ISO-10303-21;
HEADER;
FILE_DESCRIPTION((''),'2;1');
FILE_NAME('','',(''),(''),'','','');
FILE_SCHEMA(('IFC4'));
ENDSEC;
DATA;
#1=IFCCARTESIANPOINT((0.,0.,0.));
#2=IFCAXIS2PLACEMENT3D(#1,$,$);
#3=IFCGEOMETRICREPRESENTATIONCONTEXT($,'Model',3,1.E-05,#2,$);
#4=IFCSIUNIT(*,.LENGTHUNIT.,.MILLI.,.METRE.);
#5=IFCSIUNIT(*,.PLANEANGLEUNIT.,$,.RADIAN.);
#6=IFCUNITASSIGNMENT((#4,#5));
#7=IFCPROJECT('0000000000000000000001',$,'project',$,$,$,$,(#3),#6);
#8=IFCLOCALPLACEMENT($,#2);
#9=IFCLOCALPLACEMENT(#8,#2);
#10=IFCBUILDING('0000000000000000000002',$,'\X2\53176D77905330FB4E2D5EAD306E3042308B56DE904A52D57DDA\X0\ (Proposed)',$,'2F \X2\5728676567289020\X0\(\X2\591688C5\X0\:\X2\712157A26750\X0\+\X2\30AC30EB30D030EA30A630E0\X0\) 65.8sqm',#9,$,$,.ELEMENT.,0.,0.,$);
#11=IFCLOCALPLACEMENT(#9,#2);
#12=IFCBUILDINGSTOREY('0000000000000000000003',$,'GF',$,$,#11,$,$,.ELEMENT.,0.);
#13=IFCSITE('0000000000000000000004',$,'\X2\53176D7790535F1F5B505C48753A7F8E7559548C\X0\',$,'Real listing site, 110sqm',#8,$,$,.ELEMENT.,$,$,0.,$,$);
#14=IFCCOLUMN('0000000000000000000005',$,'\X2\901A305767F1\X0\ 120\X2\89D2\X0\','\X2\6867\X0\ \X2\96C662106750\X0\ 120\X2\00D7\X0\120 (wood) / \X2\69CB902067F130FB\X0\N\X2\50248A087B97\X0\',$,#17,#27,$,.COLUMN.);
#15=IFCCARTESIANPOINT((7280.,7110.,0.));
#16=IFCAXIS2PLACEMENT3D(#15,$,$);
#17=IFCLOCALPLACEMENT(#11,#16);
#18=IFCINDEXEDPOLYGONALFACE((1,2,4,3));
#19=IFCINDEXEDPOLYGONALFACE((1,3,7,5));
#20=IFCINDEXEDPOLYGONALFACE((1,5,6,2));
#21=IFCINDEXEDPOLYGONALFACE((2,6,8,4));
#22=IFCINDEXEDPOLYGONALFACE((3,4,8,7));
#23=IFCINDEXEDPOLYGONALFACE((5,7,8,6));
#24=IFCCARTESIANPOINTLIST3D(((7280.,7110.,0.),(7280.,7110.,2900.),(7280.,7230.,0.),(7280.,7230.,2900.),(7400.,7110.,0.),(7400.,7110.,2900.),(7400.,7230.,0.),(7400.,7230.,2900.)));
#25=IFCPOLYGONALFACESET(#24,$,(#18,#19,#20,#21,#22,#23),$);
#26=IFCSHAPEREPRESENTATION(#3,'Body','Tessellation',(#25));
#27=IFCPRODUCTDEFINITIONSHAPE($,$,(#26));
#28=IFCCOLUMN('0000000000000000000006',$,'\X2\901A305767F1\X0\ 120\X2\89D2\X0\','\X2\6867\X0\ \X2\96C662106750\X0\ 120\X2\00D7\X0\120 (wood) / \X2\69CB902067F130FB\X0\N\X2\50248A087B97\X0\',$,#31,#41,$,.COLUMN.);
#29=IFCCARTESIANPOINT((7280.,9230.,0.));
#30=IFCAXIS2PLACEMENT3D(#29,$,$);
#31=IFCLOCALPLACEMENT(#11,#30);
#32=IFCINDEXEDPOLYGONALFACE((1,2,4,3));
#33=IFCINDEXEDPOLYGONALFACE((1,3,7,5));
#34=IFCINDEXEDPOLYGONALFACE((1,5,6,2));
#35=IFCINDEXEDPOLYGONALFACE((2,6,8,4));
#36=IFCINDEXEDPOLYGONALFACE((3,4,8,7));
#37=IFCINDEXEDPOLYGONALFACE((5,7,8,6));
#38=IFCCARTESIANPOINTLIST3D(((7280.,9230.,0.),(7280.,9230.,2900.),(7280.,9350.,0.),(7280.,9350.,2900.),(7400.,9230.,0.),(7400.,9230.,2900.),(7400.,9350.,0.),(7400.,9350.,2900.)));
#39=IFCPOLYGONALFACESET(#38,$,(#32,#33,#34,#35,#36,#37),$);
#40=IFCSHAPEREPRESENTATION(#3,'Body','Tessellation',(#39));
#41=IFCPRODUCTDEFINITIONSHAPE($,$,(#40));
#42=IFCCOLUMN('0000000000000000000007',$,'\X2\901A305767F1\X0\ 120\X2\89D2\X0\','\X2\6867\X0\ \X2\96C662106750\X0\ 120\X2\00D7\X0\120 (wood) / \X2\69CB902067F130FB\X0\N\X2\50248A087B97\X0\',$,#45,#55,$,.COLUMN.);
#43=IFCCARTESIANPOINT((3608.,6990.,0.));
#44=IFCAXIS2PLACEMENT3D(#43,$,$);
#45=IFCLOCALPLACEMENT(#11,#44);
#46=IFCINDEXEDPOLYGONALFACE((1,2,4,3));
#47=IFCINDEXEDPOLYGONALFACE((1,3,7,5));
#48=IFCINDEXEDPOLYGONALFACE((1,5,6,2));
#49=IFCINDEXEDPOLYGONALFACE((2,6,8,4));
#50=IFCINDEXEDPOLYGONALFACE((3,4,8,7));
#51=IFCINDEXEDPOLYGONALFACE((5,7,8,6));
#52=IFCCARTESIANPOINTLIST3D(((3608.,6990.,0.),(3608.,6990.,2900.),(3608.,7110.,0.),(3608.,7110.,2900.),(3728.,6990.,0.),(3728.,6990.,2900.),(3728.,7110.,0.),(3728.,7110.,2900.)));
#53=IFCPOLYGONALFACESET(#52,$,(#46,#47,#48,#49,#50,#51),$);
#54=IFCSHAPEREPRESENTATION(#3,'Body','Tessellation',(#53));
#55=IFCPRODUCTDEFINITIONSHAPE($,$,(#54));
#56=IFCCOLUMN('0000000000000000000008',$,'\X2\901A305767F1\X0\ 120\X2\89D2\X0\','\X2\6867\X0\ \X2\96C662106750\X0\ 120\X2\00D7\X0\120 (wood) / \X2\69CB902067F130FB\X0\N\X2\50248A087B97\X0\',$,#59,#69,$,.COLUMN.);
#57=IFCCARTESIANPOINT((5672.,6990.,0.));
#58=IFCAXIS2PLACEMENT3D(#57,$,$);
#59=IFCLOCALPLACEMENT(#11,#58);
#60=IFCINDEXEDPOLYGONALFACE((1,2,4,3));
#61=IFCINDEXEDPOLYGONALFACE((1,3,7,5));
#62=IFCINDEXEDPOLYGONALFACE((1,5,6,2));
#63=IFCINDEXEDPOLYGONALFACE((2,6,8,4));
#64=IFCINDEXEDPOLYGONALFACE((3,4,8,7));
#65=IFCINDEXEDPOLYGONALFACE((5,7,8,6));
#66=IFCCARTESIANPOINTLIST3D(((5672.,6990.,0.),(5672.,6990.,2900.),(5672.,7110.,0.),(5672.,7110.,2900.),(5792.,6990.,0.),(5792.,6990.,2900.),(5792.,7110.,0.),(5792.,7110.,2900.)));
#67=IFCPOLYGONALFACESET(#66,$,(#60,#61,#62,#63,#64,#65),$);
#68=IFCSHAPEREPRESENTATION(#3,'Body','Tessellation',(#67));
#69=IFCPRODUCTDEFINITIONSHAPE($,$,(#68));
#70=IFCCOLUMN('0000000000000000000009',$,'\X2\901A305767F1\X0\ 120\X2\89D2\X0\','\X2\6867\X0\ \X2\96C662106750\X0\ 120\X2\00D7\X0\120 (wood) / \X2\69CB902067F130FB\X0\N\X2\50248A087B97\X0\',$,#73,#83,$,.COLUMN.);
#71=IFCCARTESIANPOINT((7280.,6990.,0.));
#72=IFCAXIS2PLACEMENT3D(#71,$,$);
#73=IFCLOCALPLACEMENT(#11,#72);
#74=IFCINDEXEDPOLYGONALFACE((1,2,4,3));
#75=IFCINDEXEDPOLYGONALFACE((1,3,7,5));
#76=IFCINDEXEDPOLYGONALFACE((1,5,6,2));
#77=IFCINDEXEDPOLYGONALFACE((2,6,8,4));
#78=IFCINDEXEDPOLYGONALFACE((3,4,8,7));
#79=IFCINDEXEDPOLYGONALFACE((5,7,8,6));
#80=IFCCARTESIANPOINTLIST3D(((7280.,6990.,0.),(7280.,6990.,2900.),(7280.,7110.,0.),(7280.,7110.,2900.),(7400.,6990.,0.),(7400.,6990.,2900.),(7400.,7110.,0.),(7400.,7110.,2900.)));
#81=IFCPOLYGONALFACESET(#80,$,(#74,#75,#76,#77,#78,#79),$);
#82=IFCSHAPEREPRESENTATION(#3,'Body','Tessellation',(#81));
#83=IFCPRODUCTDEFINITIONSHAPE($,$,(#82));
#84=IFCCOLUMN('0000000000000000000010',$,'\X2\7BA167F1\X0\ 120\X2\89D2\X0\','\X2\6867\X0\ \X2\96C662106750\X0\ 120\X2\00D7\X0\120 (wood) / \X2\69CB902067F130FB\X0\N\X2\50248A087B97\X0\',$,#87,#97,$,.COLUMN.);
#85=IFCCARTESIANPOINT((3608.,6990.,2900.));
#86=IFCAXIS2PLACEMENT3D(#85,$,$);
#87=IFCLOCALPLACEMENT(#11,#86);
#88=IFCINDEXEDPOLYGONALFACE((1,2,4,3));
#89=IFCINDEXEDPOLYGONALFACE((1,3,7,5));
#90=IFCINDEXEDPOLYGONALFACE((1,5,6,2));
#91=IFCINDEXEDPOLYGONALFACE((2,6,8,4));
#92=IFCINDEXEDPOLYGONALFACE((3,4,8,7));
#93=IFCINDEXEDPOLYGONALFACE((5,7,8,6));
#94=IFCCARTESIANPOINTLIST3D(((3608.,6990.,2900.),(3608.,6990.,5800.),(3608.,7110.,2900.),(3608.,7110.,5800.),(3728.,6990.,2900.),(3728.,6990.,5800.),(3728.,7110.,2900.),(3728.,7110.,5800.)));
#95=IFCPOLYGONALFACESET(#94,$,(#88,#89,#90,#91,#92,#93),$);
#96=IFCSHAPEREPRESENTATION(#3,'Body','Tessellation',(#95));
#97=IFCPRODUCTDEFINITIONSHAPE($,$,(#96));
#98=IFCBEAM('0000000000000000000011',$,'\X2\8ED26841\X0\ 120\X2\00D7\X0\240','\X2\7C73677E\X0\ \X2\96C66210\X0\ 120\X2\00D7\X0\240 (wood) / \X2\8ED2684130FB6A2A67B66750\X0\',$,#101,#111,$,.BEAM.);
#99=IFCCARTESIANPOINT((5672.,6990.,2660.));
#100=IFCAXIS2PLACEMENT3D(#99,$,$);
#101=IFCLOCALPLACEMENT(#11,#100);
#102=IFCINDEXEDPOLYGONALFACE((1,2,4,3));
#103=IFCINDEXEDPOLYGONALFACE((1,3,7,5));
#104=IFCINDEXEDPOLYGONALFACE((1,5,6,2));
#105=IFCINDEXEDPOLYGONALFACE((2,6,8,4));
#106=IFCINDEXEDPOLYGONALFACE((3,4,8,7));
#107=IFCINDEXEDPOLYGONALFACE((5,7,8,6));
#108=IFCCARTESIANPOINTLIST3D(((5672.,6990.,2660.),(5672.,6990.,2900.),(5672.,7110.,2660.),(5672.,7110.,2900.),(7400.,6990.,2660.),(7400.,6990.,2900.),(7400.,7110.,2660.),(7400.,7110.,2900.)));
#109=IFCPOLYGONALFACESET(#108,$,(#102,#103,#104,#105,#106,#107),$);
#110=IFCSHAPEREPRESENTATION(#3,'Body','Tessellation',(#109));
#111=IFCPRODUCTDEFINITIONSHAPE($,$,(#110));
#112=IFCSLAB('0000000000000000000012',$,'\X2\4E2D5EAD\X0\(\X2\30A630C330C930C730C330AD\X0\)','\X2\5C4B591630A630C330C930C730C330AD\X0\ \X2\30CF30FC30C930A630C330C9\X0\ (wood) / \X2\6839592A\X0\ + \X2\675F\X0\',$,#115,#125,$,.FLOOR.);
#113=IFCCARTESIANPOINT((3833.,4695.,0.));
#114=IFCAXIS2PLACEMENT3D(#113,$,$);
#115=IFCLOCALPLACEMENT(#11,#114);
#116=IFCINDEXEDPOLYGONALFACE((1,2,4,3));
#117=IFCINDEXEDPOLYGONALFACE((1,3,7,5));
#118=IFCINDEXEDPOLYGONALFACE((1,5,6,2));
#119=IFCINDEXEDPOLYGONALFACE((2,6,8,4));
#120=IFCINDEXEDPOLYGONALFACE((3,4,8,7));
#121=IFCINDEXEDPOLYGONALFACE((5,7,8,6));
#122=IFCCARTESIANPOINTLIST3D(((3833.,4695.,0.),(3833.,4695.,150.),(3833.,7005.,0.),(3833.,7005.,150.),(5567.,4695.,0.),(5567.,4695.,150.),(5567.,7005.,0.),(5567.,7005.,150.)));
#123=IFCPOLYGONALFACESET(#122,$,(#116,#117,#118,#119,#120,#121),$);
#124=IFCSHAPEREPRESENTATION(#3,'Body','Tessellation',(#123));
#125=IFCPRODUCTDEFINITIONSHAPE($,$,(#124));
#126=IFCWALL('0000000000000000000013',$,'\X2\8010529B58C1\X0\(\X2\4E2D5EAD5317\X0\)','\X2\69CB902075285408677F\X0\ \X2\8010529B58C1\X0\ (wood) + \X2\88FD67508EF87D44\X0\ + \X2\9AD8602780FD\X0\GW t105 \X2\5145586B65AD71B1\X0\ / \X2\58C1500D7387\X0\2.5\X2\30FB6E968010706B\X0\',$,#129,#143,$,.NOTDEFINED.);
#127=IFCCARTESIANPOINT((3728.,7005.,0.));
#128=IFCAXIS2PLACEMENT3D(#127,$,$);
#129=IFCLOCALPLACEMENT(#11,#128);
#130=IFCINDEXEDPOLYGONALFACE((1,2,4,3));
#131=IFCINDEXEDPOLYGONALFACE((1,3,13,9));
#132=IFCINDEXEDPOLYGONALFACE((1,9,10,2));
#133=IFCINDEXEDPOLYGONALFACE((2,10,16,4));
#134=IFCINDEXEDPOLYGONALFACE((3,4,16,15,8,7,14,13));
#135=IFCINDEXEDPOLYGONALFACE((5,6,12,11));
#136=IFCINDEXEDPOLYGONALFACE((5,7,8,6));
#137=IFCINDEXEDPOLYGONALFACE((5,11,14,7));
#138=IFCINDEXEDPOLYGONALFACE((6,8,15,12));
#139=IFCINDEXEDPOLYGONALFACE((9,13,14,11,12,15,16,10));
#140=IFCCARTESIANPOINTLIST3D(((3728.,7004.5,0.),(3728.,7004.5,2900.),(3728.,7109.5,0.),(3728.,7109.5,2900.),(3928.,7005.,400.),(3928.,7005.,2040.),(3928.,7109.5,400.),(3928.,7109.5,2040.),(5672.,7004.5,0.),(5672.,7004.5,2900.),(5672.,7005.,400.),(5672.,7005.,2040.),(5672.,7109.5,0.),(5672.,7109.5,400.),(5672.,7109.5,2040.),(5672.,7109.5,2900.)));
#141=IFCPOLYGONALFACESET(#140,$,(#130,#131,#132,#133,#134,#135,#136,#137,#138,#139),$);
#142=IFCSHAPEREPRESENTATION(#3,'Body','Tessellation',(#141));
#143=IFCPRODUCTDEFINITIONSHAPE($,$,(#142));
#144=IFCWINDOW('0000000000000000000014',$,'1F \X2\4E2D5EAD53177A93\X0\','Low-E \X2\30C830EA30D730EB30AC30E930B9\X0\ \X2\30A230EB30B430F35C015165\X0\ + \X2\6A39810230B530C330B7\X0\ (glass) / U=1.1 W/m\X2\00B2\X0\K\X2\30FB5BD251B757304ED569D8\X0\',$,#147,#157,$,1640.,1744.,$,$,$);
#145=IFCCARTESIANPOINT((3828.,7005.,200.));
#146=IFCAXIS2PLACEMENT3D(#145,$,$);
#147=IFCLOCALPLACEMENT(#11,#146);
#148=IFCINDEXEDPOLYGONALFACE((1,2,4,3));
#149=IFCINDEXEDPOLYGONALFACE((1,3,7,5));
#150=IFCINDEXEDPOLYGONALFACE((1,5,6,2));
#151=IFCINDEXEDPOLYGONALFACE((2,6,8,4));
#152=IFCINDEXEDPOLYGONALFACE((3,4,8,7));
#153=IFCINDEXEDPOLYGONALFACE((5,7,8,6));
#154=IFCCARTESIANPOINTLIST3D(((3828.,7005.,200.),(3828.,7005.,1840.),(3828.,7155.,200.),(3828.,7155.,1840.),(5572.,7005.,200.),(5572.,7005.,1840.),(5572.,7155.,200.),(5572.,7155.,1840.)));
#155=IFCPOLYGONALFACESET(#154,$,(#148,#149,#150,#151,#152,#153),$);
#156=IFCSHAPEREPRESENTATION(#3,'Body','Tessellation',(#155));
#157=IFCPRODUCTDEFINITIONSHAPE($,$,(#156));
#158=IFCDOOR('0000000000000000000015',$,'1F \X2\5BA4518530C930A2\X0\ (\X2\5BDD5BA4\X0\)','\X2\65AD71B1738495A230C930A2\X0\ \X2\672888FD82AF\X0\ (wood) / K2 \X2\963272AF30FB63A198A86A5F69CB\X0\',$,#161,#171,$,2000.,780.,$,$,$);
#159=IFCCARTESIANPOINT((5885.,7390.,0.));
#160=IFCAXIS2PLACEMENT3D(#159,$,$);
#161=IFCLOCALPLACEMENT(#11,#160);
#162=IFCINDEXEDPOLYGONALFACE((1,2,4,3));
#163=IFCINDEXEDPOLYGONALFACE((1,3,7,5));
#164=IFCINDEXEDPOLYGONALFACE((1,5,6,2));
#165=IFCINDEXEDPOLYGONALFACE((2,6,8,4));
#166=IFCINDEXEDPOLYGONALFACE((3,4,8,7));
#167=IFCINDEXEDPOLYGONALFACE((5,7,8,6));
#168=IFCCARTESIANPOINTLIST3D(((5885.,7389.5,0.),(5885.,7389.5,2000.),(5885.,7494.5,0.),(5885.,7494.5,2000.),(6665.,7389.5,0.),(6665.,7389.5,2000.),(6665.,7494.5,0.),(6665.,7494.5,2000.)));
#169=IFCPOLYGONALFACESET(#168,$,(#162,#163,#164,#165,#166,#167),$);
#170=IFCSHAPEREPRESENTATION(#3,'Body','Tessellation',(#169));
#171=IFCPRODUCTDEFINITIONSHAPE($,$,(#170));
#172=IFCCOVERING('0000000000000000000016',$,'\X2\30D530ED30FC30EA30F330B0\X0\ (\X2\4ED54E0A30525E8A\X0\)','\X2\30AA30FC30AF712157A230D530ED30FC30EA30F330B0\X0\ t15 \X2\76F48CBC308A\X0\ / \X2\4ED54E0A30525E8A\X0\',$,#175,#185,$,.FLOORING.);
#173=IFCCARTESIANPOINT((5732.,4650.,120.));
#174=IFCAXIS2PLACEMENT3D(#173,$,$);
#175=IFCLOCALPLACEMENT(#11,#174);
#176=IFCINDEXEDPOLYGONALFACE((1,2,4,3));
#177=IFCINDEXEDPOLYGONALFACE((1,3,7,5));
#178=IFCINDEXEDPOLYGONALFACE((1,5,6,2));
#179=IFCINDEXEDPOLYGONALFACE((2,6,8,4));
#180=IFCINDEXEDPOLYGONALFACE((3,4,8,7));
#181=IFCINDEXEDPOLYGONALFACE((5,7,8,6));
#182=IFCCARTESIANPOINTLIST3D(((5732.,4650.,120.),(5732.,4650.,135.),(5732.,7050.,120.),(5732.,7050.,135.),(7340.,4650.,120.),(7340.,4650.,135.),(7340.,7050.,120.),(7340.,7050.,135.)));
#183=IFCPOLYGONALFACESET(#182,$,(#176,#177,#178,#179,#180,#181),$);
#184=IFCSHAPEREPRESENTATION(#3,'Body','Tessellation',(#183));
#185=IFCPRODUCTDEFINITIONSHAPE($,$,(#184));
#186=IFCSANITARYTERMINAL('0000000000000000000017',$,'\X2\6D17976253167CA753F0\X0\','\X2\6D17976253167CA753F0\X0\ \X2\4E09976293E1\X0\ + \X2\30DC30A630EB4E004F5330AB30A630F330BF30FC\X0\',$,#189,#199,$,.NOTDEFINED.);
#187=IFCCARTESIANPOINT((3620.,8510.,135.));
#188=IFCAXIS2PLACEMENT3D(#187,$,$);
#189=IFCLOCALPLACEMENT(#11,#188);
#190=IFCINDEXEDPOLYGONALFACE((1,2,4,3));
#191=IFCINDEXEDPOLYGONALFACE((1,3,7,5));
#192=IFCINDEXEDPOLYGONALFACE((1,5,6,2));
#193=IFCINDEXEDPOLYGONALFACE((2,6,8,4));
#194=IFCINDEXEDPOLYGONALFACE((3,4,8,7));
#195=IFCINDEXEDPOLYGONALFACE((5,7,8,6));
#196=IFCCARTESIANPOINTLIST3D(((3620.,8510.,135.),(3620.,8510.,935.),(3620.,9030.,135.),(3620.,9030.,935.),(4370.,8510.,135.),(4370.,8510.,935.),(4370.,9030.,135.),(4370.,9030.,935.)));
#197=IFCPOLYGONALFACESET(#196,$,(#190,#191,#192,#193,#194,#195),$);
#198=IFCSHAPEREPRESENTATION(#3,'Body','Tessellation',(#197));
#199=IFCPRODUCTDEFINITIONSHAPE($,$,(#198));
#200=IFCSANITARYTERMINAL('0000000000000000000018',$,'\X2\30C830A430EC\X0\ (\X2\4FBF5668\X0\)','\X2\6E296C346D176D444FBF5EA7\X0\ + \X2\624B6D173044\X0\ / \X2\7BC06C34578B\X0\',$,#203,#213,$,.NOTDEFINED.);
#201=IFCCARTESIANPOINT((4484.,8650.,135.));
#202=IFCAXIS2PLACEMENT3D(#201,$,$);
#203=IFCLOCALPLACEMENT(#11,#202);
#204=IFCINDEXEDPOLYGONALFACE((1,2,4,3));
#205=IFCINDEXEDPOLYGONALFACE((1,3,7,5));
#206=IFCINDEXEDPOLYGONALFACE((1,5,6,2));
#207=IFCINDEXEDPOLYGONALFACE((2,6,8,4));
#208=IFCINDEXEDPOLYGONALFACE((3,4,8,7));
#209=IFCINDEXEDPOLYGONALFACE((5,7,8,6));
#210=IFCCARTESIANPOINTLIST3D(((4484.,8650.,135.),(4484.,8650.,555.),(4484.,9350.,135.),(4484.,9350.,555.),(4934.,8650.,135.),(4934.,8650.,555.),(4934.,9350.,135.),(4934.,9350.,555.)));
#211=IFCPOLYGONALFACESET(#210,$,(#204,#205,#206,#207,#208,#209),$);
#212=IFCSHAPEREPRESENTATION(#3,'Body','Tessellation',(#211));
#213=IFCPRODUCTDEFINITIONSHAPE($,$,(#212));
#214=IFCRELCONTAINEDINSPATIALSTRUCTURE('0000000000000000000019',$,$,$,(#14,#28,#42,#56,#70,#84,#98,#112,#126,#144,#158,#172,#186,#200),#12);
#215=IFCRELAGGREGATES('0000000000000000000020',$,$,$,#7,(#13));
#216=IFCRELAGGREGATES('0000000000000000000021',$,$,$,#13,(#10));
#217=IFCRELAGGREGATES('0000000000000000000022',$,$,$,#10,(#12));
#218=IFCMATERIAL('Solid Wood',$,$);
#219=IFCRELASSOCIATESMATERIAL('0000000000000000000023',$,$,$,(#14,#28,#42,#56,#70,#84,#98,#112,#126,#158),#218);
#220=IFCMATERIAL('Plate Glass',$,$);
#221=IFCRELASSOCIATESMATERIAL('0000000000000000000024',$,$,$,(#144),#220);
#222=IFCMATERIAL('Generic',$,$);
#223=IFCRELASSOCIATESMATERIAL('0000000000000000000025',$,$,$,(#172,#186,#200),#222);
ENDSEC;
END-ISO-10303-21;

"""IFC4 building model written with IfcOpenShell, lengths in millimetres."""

from ifc_helpers import new_model, si_unit, frame, frame_2d, origin, place, context, project, spatial, rectangle, extrude, material, element, fill, save


model = new_model("IFC4")

# Units and contexts
model_context = context("Model", 3, precision=1e-05, world=origin())
ifc_project = project(units=[si_unit("LENGTHUNIT", "METRE", prefix="MILLI"), si_unit("PLANEANGLEUNIT", "RADIAN")], contexts=[model_context])

# Site, building, storey
site_placement = place(None, origin())
site = spatial("IfcSite", under=ifc_project, at=site_placement, Name="北海道弟子屈町美留和", ObjectType="Real listing site, 110sqm", CompositionType="ELEMENT", RefElevation=0.0)
building_placement = place(site_placement, origin())
building = spatial("IfcBuilding", under=site, at=building_placement, Name="北海道・中庭のある回遊動線 (Proposed)", ObjectType="2F 在来木造(外装:無垢材+ガルバリウム) 65.8sqm", CompositionType="ELEMENT", ElevationOfRefHeight=0.0, ElevationOfTerrain=0.0)
storey_placement = place(building_placement, origin())
storey = spatial("IfcBuildingStorey", under=building, at=storey_placement, Name="GF", CompositionType="ELEMENT", Elevation=0.0)

# Columns
ifc_material_1 = material(Name="Solid Wood")
column_1_placement = place(storey_placement, frame((7280.0, 7110.0, 0.0)))
element("IfcColumn", 1, at=column_1_placement, inside=storey, material=ifc_material_1, Name="通し柱 120角", Description="桧 集成材 120×120 (wood) / 構造柱・N値計算", PredefinedType="COLUMN", context=model_context, shape_type="SweptSolid", body=[
    extrude(rectangle(XDim=120.0, YDim=120.0, at=frame_2d((60.0, 60.0))), frame((7280.0, 7110.0, 0.0)), (0.0, 0.0, 1.0), 2900.0),
])
column_2_placement = place(storey_placement, frame((7280.0, 9230.0, 0.0)))
element("IfcColumn", 2, at=column_2_placement, inside=storey, material=ifc_material_1, Name="通し柱 120角", Description="桧 集成材 120×120 (wood) / 構造柱・N値計算", PredefinedType="COLUMN", context=model_context, shape_type="SweptSolid", body=[
    extrude(rectangle(XDim=120.0, YDim=120.0, at=frame_2d((60.0, 60.0))), frame((7280.0, 9230.0, 0.0)), (0.0, 0.0, 1.0), 2900.0),
])
column_3_placement = place(storey_placement, frame((3608.0, 6990.0, 0.0)))
element("IfcColumn", 3, at=column_3_placement, inside=storey, material=ifc_material_1, Name="通し柱 120角", Description="桧 集成材 120×120 (wood) / 構造柱・N値計算", PredefinedType="COLUMN", context=model_context, shape_type="SweptSolid", body=[
    extrude(rectangle(XDim=120.0, YDim=120.0, at=frame_2d((60.0, 60.0))), frame((3608.0, 6990.0, 0.0)), (0.0, 0.0, 1.0), 2900.0),
])
column_4_placement = place(storey_placement, frame((5672.0, 6990.0, 0.0)))
element("IfcColumn", 4, at=column_4_placement, inside=storey, material=ifc_material_1, Name="通し柱 120角", Description="桧 集成材 120×120 (wood) / 構造柱・N値計算", PredefinedType="COLUMN", context=model_context, shape_type="SweptSolid", body=[
    extrude(rectangle(XDim=120.0, YDim=120.0, at=frame_2d((60.0, 60.0))), frame((5672.0, 6990.0, 0.0)), (0.0, 0.0, 1.0), 2900.0),
])
column_5_placement = place(storey_placement, frame((7280.0, 6990.0, 0.0)))
element("IfcColumn", 5, at=column_5_placement, inside=storey, material=ifc_material_1, Name="通し柱 120角", Description="桧 集成材 120×120 (wood) / 構造柱・N値計算", PredefinedType="COLUMN", context=model_context, shape_type="SweptSolid", body=[
    extrude(rectangle(XDim=120.0, YDim=120.0, at=frame_2d((60.0, 60.0))), frame((7280.0, 6990.0, 0.0)), (0.0, 0.0, 1.0), 2900.0),
])
column_6_placement = place(storey_placement, frame((3608.0, 6990.0, 2900.0)))
element("IfcColumn", 6, at=column_6_placement, inside=storey, material=ifc_material_1, Name="管柱 120角", Description="桧 集成材 120×120 (wood) / 構造柱・N値計算", PredefinedType="COLUMN", context=model_context, shape_type="SweptSolid", body=[
    extrude(rectangle(XDim=120.0, YDim=120.0, at=frame_2d((60.0, 60.0))), frame((3608.0, 6990.0, 2900.0)), (0.0, 0.0, 1.0), 2900.0),
])

# Beam
beam_1_placement = place(storey_placement, frame((5672.0, 6990.0, 2660.0)))
element("IfcBeam", 7, at=beam_1_placement, inside=storey, material=ifc_material_1, Name="軒桁 120×240", Description="米松 集成 120×240 (wood) / 軒桁・横架材", PredefinedType="BEAM", context=model_context, shape_type="SweptSolid", body=[
    extrude(rectangle(XDim=1728.0, YDim=120.0, at=frame_2d((864.0, 60.0))), frame((5672.0, 6990.0, 2660.0)), (0.0, 0.0, 1.0), 240.0),
])

# Slab
slab_placement = place(storey_placement, frame((3833.0, 4695.0, 0.0)))
element("IfcSlab", 8, at=slab_placement, inside=storey, material=ifc_material_1, Name="中庭(ウッドデッキ)", Description="屋外ウッドデッキ ハードウッド (wood) / 根太 + 束", PredefinedType="FLOOR", context=model_context, shape_type="SweptSolid", body=[
    extrude(rectangle(XDim=1734.0, YDim=2310.0, at=frame_2d((867.0, 1155.0))), frame((3833.0, 4695.0, 0.0)), (0.0, 0.0, 1.0), 150.0),
])

# Wall, opening, window
wall_1_placement = place(storey_placement, frame((3728.0, 7005.0, 0.0)))
wall_1 = element("IfcWall", 9, at=wall_1_placement, inside=storey, material=ifc_material_1, Name="耐力壁(中庭北)", Description="構造用合板 耐力壁 (wood) + 製材軸組 + 高性能GW t105 充填断熱 / 壁倍率2.5・準耐火", PredefinedType="NOTDEFINED", context=model_context, shape_type="SweptSolid", body=[
    extrude(rectangle(XDim=1944.0, YDim=105.0, at=frame_2d((972.0, 52.0))), frame((3728.0, 7005.0, 0.0)), (0.0, 0.0, 1.0), 2900.0),
])
opening_placement = place(storey_placement, frame((3828.0, 7005.0, 200.0)))
opening = element("IfcOpeningElement", 10, at=opening_placement, cuts=wall_1, PredefinedType="NOTDEFINED", context=model_context, shape_type="SweptSolid", body=[
    extrude(rectangle(XDim=1744.0, YDim=150.0, at=frame_2d((872.0, 75.0))), frame((3828.0, 7005.0, 200.0)), (0.0, 0.0, 1.0), 1640.0),
])
ifc_material_2 = material(Name="Plate Glass")
window_placement = place(storey_placement, frame((3828.0, 7005.0, 200.0)))
window = element("IfcWindow", 11, at=window_placement, inside=storey, material=ifc_material_2, Name="1F 中庭北窓", Description="Low-E トリプルガラス アルゴン封入 + 樹脂サッシ (glass) / U=1.1 W/m²K・寒冷地仕様", OverallHeight=1640.0, OverallWidth=1744.0, context=model_context, shape_type="SweptSolid", body=[
    extrude(rectangle(XDim=1744.0, YDim=150.0, at=frame_2d((872.0, 75.0))), frame((3828.0, 7005.0, 200.0)), (0.0, 0.0, 1.0), 1640.0),
])
fill(opening, window)

# Door
door_placement = place(storey_placement, frame((5885.0, 7390.0, 0.0)))
element("IfcDoor", 12, at=door_placement, inside=storey, material=ifc_material_1, Name="1F 室内ドア (寝室)", Description="断熱玄関ドア 木製芯 (wood) / K2 防犯・採風機構", OverallHeight=2000.0, OverallWidth=780.0, context=model_context, shape_type="SweptSolid", body=[
    extrude(rectangle(XDim=780.0, YDim=105.0, at=frame_2d((390.0, 52.0))), frame((5885.0, 7390.0, 0.0)), (0.0, 0.0, 1.0), 2000.0),
])

# Covering
ifc_material_3 = material(Name="Generic")
covering_placement = place(storey_placement, frame((5732.0, 4650.0, 120.0)))
element("IfcCovering", 13, at=covering_placement, inside=storey, material=ifc_material_3, Name="フローリング (仕上げ床)", Description="オーク無垢フローリング t15 直貼り / 仕上げ床", PredefinedType="FLOORING", context=model_context, shape_type="SweptSolid", body=[
    extrude(rectangle(XDim=1608.0, YDim=2400.0, at=frame_2d((804.0, 1200.0))), frame((5732.0, 4650.0, 120.0)), (0.0, 0.0, 1.0), 15.0),
])

# Sanitary terminals
sanitary_terminal_1_placement = place(storey_placement, frame((3620.0, 8510.0, 135.0)))
element("IfcSanitaryTerminal", 14, at=sanitary_terminal_1_placement, inside=storey, material=ifc_material_3, Name="洗面化粧台", Description="洗面化粧台 三面鏡 + ボウル一体カウンター", PredefinedType="NOTDEFINED", context=model_context, shape_type="SweptSolid", body=[
    extrude(rectangle(XDim=750.0, YDim=520.0, at=frame_2d((375.0, 260.0))), frame((3620.0, 8510.0, 135.0)), (0.0, 0.0, 1.0), 800.0),
])
sanitary_terminal_2_placement = place(storey_placement, frame((4484.0, 8650.0, 135.0)))
element("IfcSanitaryTerminal", 15, at=sanitary_terminal_2_placement, inside=storey, material=ifc_material_3, Name="トイレ (便器)", Description="温水洗浄便座 + 手洗い / 節水型", PredefinedType="NOTDEFINED", context=model_context, shape_type="SweptSolid", body=[
    extrude(rectangle(XDim=450.0, YDim=700.0, at=frame_2d((225.0, 350.0))), frame((4484.0, 8650.0, 135.0)), (0.0, 0.0, 1.0), 420.0),
])

save(model, "model.ifc")
